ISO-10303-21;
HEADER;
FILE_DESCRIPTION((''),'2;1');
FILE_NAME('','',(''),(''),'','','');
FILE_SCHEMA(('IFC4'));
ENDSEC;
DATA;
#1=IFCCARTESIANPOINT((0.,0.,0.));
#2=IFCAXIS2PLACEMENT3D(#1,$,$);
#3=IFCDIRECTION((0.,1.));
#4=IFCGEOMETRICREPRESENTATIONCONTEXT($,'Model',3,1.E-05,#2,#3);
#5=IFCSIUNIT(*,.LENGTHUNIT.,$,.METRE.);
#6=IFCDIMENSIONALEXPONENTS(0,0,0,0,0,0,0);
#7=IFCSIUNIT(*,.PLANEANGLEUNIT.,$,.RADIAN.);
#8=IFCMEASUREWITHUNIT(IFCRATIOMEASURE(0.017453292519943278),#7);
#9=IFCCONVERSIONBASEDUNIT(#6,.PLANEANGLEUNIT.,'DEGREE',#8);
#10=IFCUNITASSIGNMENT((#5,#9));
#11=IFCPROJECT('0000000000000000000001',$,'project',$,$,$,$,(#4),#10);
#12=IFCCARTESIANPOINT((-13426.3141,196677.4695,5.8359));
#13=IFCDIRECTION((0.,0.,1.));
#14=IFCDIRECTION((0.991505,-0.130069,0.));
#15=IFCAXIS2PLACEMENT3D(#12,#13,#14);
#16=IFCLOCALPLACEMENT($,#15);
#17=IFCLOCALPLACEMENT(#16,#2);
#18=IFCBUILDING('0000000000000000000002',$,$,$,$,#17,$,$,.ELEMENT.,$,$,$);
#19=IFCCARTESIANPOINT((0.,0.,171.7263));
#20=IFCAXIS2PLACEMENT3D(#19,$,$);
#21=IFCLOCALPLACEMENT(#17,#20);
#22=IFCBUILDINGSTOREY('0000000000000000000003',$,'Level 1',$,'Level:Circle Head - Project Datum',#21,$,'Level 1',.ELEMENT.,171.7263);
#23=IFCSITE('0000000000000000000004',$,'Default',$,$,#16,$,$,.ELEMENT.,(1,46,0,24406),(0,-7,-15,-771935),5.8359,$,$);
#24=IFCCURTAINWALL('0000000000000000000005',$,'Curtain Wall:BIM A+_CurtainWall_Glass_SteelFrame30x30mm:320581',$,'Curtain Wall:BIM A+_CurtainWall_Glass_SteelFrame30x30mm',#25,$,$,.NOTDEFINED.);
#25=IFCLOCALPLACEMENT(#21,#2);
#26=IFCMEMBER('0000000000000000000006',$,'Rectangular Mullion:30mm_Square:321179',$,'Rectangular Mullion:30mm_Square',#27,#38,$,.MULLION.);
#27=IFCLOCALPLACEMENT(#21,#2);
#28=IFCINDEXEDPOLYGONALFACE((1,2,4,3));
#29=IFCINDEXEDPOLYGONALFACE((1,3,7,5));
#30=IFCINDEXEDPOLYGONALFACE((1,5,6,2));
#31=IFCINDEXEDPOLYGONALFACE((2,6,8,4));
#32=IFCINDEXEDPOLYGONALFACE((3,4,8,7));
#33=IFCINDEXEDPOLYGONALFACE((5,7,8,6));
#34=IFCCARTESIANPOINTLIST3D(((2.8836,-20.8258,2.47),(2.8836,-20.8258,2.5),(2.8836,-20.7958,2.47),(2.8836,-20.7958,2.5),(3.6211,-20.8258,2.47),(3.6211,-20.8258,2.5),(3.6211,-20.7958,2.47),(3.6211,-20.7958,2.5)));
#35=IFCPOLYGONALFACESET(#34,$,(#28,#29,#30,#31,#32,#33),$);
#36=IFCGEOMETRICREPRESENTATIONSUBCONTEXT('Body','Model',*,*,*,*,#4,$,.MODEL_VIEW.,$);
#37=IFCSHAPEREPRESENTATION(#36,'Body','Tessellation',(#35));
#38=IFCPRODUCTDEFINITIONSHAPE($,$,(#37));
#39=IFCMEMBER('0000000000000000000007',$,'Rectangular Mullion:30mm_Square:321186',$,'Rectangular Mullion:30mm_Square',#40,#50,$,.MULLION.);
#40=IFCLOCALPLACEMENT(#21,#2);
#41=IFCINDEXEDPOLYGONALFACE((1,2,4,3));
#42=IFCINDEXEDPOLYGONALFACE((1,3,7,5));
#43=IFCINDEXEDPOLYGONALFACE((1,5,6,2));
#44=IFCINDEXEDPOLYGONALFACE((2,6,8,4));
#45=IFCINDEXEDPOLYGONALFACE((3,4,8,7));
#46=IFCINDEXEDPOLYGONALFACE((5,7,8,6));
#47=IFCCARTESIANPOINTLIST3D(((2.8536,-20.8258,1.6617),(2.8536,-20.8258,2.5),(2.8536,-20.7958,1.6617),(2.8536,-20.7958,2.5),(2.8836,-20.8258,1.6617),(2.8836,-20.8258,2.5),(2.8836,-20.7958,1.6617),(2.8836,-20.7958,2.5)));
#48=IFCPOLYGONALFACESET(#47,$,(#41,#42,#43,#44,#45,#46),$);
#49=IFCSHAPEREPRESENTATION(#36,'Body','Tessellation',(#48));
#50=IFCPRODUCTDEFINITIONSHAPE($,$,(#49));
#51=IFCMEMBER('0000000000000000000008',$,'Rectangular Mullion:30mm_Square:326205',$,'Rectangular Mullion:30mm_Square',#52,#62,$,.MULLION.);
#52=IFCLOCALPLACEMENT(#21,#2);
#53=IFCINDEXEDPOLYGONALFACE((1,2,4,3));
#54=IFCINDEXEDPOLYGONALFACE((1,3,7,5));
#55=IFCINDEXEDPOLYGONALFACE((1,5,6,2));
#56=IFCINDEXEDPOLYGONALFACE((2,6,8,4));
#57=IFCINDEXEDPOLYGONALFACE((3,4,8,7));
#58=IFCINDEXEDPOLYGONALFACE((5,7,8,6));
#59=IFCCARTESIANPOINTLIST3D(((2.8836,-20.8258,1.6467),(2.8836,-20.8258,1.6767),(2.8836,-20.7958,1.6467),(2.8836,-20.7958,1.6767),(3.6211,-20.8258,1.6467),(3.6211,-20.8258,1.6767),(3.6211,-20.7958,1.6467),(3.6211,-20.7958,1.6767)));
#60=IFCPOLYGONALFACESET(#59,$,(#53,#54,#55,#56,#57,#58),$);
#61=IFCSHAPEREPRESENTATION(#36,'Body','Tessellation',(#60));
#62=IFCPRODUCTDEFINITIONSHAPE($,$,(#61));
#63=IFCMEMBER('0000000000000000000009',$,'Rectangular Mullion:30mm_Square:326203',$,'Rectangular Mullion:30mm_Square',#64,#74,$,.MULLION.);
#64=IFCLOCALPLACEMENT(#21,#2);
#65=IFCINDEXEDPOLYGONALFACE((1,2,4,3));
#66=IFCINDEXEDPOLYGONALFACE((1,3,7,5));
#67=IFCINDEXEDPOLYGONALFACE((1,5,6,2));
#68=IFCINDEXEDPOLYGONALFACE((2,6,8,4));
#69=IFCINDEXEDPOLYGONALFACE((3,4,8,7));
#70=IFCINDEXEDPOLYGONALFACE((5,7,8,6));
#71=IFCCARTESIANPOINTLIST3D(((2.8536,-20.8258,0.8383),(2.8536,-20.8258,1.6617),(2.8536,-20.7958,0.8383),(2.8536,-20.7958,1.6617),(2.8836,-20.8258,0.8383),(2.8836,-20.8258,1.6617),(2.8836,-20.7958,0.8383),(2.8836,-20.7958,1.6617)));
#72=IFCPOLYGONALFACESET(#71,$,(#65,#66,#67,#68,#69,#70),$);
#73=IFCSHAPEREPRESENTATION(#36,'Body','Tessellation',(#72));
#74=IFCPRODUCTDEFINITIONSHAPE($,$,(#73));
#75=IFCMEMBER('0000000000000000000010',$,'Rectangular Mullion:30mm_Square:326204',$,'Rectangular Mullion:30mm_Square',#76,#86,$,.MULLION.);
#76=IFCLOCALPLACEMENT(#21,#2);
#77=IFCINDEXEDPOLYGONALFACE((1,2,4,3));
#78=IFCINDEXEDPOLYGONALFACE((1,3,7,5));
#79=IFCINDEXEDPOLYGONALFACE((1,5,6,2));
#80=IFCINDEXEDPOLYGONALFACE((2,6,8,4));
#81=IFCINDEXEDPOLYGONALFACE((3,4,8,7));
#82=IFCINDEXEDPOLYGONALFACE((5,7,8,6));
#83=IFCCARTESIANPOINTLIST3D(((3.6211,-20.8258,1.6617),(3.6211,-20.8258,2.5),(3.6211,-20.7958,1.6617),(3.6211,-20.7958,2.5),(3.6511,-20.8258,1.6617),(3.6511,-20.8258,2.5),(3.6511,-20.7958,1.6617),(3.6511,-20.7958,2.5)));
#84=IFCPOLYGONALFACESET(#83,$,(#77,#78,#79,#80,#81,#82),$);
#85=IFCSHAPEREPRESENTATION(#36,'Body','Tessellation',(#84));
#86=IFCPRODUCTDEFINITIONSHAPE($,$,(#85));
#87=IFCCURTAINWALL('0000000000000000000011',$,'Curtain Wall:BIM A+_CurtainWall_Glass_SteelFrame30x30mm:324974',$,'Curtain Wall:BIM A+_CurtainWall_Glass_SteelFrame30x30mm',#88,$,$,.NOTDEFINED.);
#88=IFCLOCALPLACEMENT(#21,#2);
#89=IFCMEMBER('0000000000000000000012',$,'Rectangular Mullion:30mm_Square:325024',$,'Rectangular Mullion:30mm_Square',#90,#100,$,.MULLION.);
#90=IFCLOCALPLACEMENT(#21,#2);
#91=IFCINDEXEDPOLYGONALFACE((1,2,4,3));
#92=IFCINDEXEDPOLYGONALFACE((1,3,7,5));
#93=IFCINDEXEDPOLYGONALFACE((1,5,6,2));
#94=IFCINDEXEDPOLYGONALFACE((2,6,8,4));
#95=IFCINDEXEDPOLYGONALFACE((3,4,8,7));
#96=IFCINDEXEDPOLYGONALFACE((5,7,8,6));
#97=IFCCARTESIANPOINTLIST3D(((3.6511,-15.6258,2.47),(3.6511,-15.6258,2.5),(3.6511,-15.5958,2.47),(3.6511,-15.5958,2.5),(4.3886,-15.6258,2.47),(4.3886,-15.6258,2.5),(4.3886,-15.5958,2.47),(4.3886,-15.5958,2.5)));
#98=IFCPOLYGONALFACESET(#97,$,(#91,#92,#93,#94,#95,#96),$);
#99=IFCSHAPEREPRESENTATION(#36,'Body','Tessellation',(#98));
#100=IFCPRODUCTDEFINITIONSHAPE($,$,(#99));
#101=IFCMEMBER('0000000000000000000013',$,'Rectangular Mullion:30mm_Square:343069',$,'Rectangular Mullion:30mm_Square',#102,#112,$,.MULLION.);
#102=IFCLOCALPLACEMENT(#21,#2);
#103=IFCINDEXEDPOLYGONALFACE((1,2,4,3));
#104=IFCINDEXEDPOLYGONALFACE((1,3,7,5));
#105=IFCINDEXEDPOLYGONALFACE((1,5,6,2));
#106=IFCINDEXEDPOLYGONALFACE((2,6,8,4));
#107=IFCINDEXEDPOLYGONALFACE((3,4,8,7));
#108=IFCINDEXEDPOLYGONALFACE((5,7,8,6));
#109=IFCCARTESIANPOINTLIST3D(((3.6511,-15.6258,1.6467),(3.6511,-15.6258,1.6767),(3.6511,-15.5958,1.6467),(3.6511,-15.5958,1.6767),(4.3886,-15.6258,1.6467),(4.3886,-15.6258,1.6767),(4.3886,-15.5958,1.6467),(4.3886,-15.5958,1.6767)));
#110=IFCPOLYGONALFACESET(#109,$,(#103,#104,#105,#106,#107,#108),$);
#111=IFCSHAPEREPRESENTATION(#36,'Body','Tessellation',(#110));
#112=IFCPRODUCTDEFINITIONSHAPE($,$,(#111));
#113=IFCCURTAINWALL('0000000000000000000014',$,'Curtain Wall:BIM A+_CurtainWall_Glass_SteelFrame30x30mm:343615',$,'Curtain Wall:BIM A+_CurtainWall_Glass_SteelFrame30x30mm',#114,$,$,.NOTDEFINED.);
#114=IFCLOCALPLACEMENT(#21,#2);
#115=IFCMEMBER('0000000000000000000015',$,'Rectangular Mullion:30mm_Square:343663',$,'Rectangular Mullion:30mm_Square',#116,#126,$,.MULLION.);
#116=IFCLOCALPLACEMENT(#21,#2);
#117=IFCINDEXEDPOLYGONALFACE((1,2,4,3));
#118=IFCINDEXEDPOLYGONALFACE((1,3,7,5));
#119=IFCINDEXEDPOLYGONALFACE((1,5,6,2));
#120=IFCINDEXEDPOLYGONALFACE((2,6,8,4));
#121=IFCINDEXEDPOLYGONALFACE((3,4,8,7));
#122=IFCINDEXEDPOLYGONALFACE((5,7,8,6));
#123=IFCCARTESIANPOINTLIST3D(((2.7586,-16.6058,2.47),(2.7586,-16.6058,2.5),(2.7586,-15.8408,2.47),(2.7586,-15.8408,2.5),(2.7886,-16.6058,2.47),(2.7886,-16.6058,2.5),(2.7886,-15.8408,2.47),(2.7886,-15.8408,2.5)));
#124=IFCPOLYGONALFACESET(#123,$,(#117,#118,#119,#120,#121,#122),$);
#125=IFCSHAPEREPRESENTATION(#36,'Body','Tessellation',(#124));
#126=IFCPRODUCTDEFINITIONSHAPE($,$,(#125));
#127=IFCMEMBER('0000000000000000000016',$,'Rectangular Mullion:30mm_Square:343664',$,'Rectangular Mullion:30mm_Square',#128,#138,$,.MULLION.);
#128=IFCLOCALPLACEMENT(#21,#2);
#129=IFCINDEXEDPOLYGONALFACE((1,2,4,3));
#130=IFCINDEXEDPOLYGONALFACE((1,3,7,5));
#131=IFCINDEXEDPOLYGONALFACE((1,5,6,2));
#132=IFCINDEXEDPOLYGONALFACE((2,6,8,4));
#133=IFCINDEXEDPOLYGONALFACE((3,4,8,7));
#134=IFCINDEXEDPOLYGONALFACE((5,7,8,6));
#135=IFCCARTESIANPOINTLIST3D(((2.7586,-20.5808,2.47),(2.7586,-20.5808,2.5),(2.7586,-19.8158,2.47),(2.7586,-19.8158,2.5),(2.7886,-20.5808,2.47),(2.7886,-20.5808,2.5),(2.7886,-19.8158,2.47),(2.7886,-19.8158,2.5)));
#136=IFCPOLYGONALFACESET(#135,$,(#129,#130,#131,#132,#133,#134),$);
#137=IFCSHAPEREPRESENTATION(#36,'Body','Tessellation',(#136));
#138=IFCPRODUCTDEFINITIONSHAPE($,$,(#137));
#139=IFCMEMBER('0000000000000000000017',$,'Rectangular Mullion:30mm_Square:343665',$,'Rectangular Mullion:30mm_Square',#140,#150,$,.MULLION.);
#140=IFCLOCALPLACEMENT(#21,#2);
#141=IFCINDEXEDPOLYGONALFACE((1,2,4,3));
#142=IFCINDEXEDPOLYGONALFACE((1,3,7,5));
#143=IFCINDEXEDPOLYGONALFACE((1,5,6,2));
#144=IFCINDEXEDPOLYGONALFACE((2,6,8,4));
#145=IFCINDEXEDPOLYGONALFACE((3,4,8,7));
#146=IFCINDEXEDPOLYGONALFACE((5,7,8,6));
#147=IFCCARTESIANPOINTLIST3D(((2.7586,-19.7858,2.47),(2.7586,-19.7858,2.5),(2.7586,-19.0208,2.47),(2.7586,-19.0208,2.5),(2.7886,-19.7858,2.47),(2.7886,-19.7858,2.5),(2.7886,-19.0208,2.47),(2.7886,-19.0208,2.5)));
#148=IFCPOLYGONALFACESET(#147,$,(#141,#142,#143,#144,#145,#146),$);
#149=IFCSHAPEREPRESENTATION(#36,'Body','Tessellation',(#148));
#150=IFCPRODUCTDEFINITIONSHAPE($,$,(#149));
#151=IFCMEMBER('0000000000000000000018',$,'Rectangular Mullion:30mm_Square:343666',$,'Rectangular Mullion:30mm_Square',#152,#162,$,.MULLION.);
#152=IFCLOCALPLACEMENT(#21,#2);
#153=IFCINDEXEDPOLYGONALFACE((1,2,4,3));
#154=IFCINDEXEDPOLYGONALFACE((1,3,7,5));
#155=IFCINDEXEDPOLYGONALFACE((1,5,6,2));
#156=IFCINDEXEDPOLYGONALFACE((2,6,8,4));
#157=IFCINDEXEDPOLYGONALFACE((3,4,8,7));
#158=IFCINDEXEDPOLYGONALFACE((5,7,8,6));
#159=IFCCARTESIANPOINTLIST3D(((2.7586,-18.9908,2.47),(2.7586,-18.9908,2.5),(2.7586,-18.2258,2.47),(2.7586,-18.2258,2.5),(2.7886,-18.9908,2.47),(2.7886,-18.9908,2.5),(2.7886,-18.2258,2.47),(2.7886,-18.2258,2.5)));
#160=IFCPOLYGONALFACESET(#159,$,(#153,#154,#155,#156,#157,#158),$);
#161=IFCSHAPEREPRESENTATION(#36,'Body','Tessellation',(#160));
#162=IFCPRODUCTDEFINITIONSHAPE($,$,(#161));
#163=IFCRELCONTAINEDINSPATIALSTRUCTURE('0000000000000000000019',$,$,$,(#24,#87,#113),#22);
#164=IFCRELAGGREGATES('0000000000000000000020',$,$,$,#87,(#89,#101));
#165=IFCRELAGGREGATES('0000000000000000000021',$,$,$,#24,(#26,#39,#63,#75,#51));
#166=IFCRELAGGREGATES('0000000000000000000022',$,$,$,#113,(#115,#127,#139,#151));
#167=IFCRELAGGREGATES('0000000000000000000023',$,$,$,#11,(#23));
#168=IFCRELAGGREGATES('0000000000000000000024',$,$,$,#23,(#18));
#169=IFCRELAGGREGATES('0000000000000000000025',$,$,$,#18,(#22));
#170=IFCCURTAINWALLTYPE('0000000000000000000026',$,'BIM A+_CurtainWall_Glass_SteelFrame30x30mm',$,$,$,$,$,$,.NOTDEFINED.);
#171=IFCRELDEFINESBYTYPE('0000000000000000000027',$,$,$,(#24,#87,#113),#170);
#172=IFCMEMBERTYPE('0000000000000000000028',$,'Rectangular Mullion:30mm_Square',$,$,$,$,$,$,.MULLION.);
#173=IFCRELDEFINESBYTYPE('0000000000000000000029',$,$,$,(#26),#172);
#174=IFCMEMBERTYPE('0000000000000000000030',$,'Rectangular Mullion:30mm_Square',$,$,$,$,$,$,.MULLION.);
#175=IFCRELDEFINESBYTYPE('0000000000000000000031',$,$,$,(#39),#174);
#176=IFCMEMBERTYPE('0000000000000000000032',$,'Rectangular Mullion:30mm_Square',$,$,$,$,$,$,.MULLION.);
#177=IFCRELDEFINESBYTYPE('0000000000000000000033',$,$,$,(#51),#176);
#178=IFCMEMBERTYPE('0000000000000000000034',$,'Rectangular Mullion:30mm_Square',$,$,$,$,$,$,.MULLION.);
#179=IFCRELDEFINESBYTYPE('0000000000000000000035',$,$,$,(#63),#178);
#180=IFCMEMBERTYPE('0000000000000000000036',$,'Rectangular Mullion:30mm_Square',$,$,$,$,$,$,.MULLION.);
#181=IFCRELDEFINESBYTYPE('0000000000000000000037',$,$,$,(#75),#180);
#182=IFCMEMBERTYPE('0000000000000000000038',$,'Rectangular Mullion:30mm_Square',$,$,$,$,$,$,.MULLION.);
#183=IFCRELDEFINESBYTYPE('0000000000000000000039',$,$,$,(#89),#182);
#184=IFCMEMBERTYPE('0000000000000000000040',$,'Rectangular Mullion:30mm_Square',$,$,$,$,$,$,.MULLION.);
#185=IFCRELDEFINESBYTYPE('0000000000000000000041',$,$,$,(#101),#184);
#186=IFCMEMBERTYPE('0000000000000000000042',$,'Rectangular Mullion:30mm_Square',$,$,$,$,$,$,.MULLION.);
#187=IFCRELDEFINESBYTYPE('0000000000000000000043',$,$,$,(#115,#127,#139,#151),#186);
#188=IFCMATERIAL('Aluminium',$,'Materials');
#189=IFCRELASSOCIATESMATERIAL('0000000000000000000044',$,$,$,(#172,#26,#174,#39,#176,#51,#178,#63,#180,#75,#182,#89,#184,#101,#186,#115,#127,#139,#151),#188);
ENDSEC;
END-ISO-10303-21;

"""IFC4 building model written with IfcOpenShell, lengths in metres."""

from ifc_helpers import new_model, entity, si_unit, converted_unit, direction, frame, origin, place, context, subcontext, project, spatial, indexed_curve, outline, extrude, source, transform, mapped, material, type_object, type_shapes, element, aggregate, save


model = new_model("IFC4")

# Units and contexts
model_context = context("Model", 3, precision=1e-05, world=origin(), true_north=direction((0.0, 1.0)))
body_context = subcontext(model_context, "Body", "Model", "MODEL_VIEW")
ifc_project = project(units=[si_unit("LENGTHUNIT", "METRE"), converted_unit("PLANEANGLEUNIT", "DEGREE", entity("IfcRatioMeasure", 0.017453292519943278), si_unit("PLANEANGLEUNIT", "RADIAN"), dimensions=[0, 0, 0, 0, 0, 0, 0])], contexts=[model_context])

# Site, building, storey
site_placement = place(None, frame((-13426.3141, 196677.4695, 5.8359), z_axis=(0.0, 0.0, 1.0), x_axis=(0.991505, -0.130069, 0.0)))
site = spatial("IfcSite", under=ifc_project, at=site_placement, Name="Default", CompositionType="ELEMENT", RefLatitude=(1, 46, 0, 24406), RefLongitude=(0, -7, -15, -771935), RefElevation=5.8359)
building_placement = place(site_placement, origin())
building = spatial("IfcBuilding", under=site, at=building_placement, CompositionType="ELEMENT")
storey_placement = place(building_placement, frame((0.0, 0.0, 171.7263)))
storey = spatial("IfcBuildingStorey", under=building, at=storey_placement, Name="Level 1", ObjectType="Level:Circle Head - Project Datum", LongName="Level 1", CompositionType="ELEMENT", Elevation=171.7263)

# Curtain walls, members
curtain_wall_type_1 = type_object("IfcCurtainWallType", Name="BIM A+_CurtainWall_Glass_SteelFrame30x30mm", PredefinedType="NOTDEFINED")
curtain_wall_1_placement = place(storey_placement, frame((0.0, 0.0, -171.7263)))
curtain_wall_1 = element("IfcCurtainWall", 1, at=curtain_wall_1_placement, inside=storey, type_object=curtain_wall_type_1, Name="Curtain Wall:BIM A+_CurtainWall_Glass_SteelFrame30x30mm:320581", ObjectType="Curtain Wall:BIM A+_CurtainWall_Glass_SteelFrame30x30mm", PredefinedType="NOTDEFINED")
ifc_material_1 = material(Name="Aluminium", Category="Materials")
member_type_1 = type_object("IfcMemberType", Name="Rectangular Mullion:30mm_Square", PredefinedType="MULLION", material=ifc_material_1)
shared_shape_1 = source(origin(), body_context, "Body", "SweptSolid", [
    extrude(outline(indexed_curve([(-0.015, -0.015), (0.015, -0.015), (0.015, 0.015), (-0.015, 0.015), (-0.015, -0.015)], self_intersect=False)), frame((-0.015, 0.0, -0.7375), z_axis=(0.0, 0.0, 1.0), x_axis=(0.0, -1.0, 0.0)), (0.0, 0.0, 1.0), 0.7375),
])
type_shapes(member_type_1, [shared_shape_1])
member_1_placement = place(curtain_wall_1_placement, frame((3.6211, -20.8108, 174.2263), z_axis=(1.0, 0.0, 0.0), x_axis=(0.0, 0.0, 1.0)))
member_1 = element("IfcMember", 2, at=member_1_placement, type_object=member_type_1, material=ifc_material_1, Name="Rectangular Mullion:30mm_Square:321179", ObjectType="Rectangular Mullion:30mm_Square", PredefinedType="MULLION", context=body_context, shape_type="MappedRepresentation", body=[
    mapped(shared_shape_1, transform((0.0, 0.0, 0.0), scale=1.0)),
])
member_type_2 = type_object("IfcMemberType", Name="Rectangular Mullion:30mm_Square", PredefinedType="MULLION", material=ifc_material_1)
shared_shape_2 = source(origin(), body_context, "Body", "SweptSolid", [
    extrude(outline(indexed_curve([(-0.015, -0.015), (0.015, -0.015), (0.015, 0.015), (-0.015, 0.015), (-0.015, -0.015)], self_intersect=False)), frame((-0.015, 0.0, -0.8383), z_axis=(0.0, 0.0, 1.0), x_axis=(0.0, -1.0, 0.0)), (0.0, 0.0, 1.0), 0.8383),
])
type_shapes(member_type_2, [shared_shape_2])
member_2_placement = place(curtain_wall_1_placement, frame((2.8536, -20.8108, 174.2263), z_axis=(0.0, 0.0, 1.0), x_axis=(-1.0, 0.0, 0.0)))
member_2 = element("IfcMember", 3, at=member_2_placement, type_object=member_type_2, material=ifc_material_1, Name="Rectangular Mullion:30mm_Square:321186", ObjectType="Rectangular Mullion:30mm_Square", PredefinedType="MULLION", context=body_context, shape_type="MappedRepresentation", body=[
    mapped(shared_shape_2, transform((0.0, 0.0, 0.0), scale=1.0)),
])
member_type_3 = type_object("IfcMemberType", Name="Rectangular Mullion:30mm_Square", PredefinedType="MULLION", material=ifc_material_1)
shared_shape_3 = source(origin(), body_context, "Body", "SweptSolid", [
    extrude(outline(indexed_curve([(-0.015, -0.015), (0.015, -0.015), (0.015, 0.015), (-0.015, 0.015), (-0.015, -0.015)], self_intersect=False)), frame((0.0, 0.0, -0.7375), z_axis=(0.0, 0.0, 1.0), x_axis=(0.0, -1.0, 0.0)), (0.0, 0.0, 1.0), 0.7375),
])
type_shapes(member_type_3, [shared_shape_3])
member_3_placement = place(curtain_wall_1_placement, frame((3.6211, -20.8108, 173.3879), z_axis=(1.0, 0.0, 0.0), x_axis=(0.0, 0.0, 1.0)))
member_3 = element("IfcMember", 4, at=member_3_placement, type_object=member_type_3, material=ifc_material_1, Name="Rectangular Mullion:30mm_Square:326205", ObjectType="Rectangular Mullion:30mm_Square", PredefinedType="MULLION", context=body_context, shape_type="MappedRepresentation", body=[
    mapped(shared_shape_3, transform((0.0, 0.0, 0.0), scale=1.0)),
])
member_type_4 = type_object("IfcMemberType", Name="Rectangular Mullion:30mm_Square", PredefinedType="MULLION", material=ifc_material_1)
shared_shape_4 = source(origin(), body_context, "Body", "SweptSolid", [
    extrude(outline(indexed_curve([(-0.015, -0.015), (0.015, -0.015), (0.015, 0.015), (-0.015, 0.015), (-0.015, -0.015)], self_intersect=False)), frame((-0.015, 0.0, -0.8233), z_axis=(0.0, 0.0, 1.0), x_axis=(0.0, -1.0, 0.0)), (0.0, 0.0, 1.0), 0.8233),
])
type_shapes(member_type_4, [shared_shape_4])
member_4_placement = place(curtain_wall_1_placement, frame((2.8536, -20.8108, 173.3879), z_axis=(0.0, 0.0, 1.0), x_axis=(-1.0, 0.0, 0.0)))
member_4 = element("IfcMember", 5, at=member_4_placement, type_object=member_type_4, material=ifc_material_1, Name="Rectangular Mullion:30mm_Square:326203", ObjectType="Rectangular Mullion:30mm_Square", PredefinedType="MULLION", context=body_context, shape_type="MappedRepresentation", body=[
    mapped(shared_shape_4, transform((0.0, 0.0, 0.0), scale=1.0)),
])
member_type_5 = type_object("IfcMemberType", Name="Rectangular Mullion:30mm_Square", PredefinedType="MULLION", material=ifc_material_1)
shared_shape_5 = source(origin(), body_context, "Body", "SweptSolid", [
    extrude(outline(indexed_curve([(-0.015, -0.015), (0.015, -0.015), (0.015, 0.015), (-0.015, 0.015), (-0.015, -0.015)], self_intersect=False)), frame((0.0, 0.0, -0.8383), z_axis=(0.0, 0.0, 1.0), x_axis=(0.0, -1.0, 0.0)), (0.0, 0.0, 1.0), 0.8383),
])
type_shapes(member_type_5, [shared_shape_5])
member_5_placement = place(curtain_wall_1_placement, frame((3.6361, -20.8108, 173.3879), z_axis=(0.0, 0.0, -1.0), x_axis=(1.0, 0.0, 0.0)))
member_5 = element("IfcMember", 6, at=member_5_placement, type_object=member_type_5, material=ifc_material_1, Name="Rectangular Mullion:30mm_Square:326204", ObjectType="Rectangular Mullion:30mm_Square", PredefinedType="MULLION", context=body_context, shape_type="MappedRepresentation", body=[
    mapped(shared_shape_5, transform((0.0, 0.0, 0.0), scale=1.0)),
])
curtain_wall_2_placement = place(storey_placement, frame((0.0, 0.0, -171.7263)))
curtain_wall_2 = element("IfcCurtainWall", 7, at=curtain_wall_2_placement, inside=storey, type_object=curtain_wall_type_1, Name="Curtain Wall:BIM A+_CurtainWall_Glass_SteelFrame30x30mm:324974", ObjectType="Curtain Wall:BIM A+_CurtainWall_Glass_SteelFrame30x30mm", PredefinedType="NOTDEFINED")
member_type_6 = type_object("IfcMemberType", Name="Rectangular Mullion:30mm_Square", PredefinedType="MULLION", material=ifc_material_1)
shared_shape_6 = source(origin(), body_context, "Body", "SweptSolid", [
    extrude(outline(indexed_curve([(-0.015, -0.015), (0.015, -0.015), (0.015, 0.015), (-0.015, 0.015), (-0.015, -0.015)], self_intersect=False)), frame((-0.015, 0.0, -0.7375), z_axis=(0.0, 0.0, 1.0), x_axis=(0.0, -1.0, 0.0)), (0.0, 0.0, 1.0), 0.7375),
])
type_shapes(member_type_6, [shared_shape_6])
member_6_placement = place(curtain_wall_2_placement, frame((3.6511, -15.6108, 174.2263), z_axis=(-1.0, 0.0, 0.0), x_axis=(0.0, 0.0, 1.0)))
member_6 = element("IfcMember", 8, at=member_6_placement, type_object=member_type_6, material=ifc_material_1, Name="Rectangular Mullion:30mm_Square:325024", ObjectType="Rectangular Mullion:30mm_Square", PredefinedType="MULLION", context=body_context, shape_type="MappedRepresentation", body=[
    mapped(shared_shape_6, transform((0.0, 0.0, 0.0), scale=1.0)),
])
member_type_7 = type_object("IfcMemberType", Name="Rectangular Mullion:30mm_Square", PredefinedType="MULLION", material=ifc_material_1)
shared_shape_7 = source(origin(), body_context, "Body", "SweptSolid", [
    extrude(outline(indexed_curve([(-0.015, -0.015), (0.015, -0.015), (0.015, 0.015), (-0.015, 0.015), (-0.015, -0.015)], self_intersect=False)), frame((0.0, 0.0, -0.7375), z_axis=(0.0, 0.0, 1.0), x_axis=(0.0, -1.0, 0.0)), (0.0, 0.0, 1.0), 0.7375),
])
type_shapes(member_type_7, [shared_shape_7])
member_7_placement = place(curtain_wall_2_placement, frame((3.6511, -15.6108, 173.3879), z_axis=(-1.0, 0.0, 0.0), x_axis=(0.0, 0.0, 1.0)))
member_7 = element("IfcMember", 9, at=member_7_placement, type_object=member_type_7, material=ifc_material_1, Name="Rectangular Mullion:30mm_Square:343069", ObjectType="Rectangular Mullion:30mm_Square", PredefinedType="MULLION", context=body_context, shape_type="MappedRepresentation", body=[
    mapped(shared_shape_7, transform((0.0, 0.0, 0.0), scale=1.0)),
])
aggregate(curtain_wall_2, [member_6, member_7])
curtain_wall_3_placement = place(storey_placement, frame((0.0, 0.0, -171.7263)))
curtain_wall_3 = element("IfcCurtainWall", 10, at=curtain_wall_3_placement, inside=storey, type_object=curtain_wall_type_1, Name="Curtain Wall:BIM A+_CurtainWall_Glass_SteelFrame30x30mm:343615", ObjectType="Curtain Wall:BIM A+_CurtainWall_Glass_SteelFrame30x30mm", PredefinedType="NOTDEFINED")
member_type_8 = type_object("IfcMemberType", Name="Rectangular Mullion:30mm_Square", PredefinedType="MULLION", material=ifc_material_1)
shared_shape_8 = source(origin(), body_context, "Body", "SweptSolid", [
    extrude(outline(indexed_curve([(-0.015, -0.015), (0.015, -0.015), (0.015, 0.015), (-0.015, 0.015), (-0.015, -0.015)], self_intersect=False)), frame((-0.015, 0.0, -0.765), z_axis=(0.0, 0.0, 1.0), x_axis=(0.0, -1.0, 0.0)), (0.0, 0.0, 1.0), 0.765),
])
type_shapes(member_type_8, [shared_shape_8])
member_8_placement = place(curtain_wall_3_placement, frame((2.7736, -15.8408, 174.2263), z_axis=(0.0, 1.0, 0.0), x_axis=(0.0, 0.0, 1.0)))
member_8 = element("IfcMember", 11, at=member_8_placement, type_object=member_type_8, material=ifc_material_1, Name="Rectangular Mullion:30mm_Square:343663", ObjectType="Rectangular Mullion:30mm_Square", PredefinedType="MULLION", context=body_context, shape_type="MappedRepresentation", body=[
    mapped(shared_shape_8, transform((0.0, 0.0, 0.0), scale=1.0)),
])
member_9_placement = place(curtain_wall_3_placement, frame((2.7736, -19.8158, 174.2263), z_axis=(0.0, 1.0, 0.0), x_axis=(0.0, 0.0, 1.0)))
member_9 = element("IfcMember", 12, at=member_9_placement, type_object=member_type_8, material=ifc_material_1, Name="Rectangular Mullion:30mm_Square:343664", ObjectType="Rectangular Mullion:30mm_Square", PredefinedType="MULLION", context=body_context, shape_type="MappedRepresentation", body=[
    mapped(shared_shape_8, transform((0.0, 0.0, 0.0), scale=1.0)),
])
member_10_placement = place(curtain_wall_3_placement, frame((2.7736, -19.0208, 174.2263), z_axis=(0.0, 1.0, 0.0), x_axis=(0.0, 0.0, 1.0)))
member_10 = element("IfcMember", 13, at=member_10_placement, type_object=member_type_8, material=ifc_material_1, Name="Rectangular Mullion:30mm_Square:343665", ObjectType="Rectangular Mullion:30mm_Square", PredefinedType="MULLION", context=body_context, shape_type="MappedRepresentation", body=[
    mapped(shared_shape_8, transform((0.0, 0.0, 0.0), scale=1.0)),
])
member_11_placement = place(curtain_wall_3_placement, frame((2.7736, -18.2258, 174.2263), z_axis=(0.0, 1.0, 0.0), x_axis=(0.0, 0.0, 1.0)))
member_11 = element("IfcMember", 14, at=member_11_placement, type_object=member_type_8, material=ifc_material_1, Name="Rectangular Mullion:30mm_Square:343666", ObjectType="Rectangular Mullion:30mm_Square", PredefinedType="MULLION", context=body_context, shape_type="MappedRepresentation", body=[
    mapped(shared_shape_8, transform((0.0, 0.0, 0.0), scale=1.0)),
])

aggregate(curtain_wall_1, [member_1, member_2, member_4, member_5, member_3])
aggregate(curtain_wall_3, [member_8, member_9, member_10, member_11])

save(model, "model.ifc")
